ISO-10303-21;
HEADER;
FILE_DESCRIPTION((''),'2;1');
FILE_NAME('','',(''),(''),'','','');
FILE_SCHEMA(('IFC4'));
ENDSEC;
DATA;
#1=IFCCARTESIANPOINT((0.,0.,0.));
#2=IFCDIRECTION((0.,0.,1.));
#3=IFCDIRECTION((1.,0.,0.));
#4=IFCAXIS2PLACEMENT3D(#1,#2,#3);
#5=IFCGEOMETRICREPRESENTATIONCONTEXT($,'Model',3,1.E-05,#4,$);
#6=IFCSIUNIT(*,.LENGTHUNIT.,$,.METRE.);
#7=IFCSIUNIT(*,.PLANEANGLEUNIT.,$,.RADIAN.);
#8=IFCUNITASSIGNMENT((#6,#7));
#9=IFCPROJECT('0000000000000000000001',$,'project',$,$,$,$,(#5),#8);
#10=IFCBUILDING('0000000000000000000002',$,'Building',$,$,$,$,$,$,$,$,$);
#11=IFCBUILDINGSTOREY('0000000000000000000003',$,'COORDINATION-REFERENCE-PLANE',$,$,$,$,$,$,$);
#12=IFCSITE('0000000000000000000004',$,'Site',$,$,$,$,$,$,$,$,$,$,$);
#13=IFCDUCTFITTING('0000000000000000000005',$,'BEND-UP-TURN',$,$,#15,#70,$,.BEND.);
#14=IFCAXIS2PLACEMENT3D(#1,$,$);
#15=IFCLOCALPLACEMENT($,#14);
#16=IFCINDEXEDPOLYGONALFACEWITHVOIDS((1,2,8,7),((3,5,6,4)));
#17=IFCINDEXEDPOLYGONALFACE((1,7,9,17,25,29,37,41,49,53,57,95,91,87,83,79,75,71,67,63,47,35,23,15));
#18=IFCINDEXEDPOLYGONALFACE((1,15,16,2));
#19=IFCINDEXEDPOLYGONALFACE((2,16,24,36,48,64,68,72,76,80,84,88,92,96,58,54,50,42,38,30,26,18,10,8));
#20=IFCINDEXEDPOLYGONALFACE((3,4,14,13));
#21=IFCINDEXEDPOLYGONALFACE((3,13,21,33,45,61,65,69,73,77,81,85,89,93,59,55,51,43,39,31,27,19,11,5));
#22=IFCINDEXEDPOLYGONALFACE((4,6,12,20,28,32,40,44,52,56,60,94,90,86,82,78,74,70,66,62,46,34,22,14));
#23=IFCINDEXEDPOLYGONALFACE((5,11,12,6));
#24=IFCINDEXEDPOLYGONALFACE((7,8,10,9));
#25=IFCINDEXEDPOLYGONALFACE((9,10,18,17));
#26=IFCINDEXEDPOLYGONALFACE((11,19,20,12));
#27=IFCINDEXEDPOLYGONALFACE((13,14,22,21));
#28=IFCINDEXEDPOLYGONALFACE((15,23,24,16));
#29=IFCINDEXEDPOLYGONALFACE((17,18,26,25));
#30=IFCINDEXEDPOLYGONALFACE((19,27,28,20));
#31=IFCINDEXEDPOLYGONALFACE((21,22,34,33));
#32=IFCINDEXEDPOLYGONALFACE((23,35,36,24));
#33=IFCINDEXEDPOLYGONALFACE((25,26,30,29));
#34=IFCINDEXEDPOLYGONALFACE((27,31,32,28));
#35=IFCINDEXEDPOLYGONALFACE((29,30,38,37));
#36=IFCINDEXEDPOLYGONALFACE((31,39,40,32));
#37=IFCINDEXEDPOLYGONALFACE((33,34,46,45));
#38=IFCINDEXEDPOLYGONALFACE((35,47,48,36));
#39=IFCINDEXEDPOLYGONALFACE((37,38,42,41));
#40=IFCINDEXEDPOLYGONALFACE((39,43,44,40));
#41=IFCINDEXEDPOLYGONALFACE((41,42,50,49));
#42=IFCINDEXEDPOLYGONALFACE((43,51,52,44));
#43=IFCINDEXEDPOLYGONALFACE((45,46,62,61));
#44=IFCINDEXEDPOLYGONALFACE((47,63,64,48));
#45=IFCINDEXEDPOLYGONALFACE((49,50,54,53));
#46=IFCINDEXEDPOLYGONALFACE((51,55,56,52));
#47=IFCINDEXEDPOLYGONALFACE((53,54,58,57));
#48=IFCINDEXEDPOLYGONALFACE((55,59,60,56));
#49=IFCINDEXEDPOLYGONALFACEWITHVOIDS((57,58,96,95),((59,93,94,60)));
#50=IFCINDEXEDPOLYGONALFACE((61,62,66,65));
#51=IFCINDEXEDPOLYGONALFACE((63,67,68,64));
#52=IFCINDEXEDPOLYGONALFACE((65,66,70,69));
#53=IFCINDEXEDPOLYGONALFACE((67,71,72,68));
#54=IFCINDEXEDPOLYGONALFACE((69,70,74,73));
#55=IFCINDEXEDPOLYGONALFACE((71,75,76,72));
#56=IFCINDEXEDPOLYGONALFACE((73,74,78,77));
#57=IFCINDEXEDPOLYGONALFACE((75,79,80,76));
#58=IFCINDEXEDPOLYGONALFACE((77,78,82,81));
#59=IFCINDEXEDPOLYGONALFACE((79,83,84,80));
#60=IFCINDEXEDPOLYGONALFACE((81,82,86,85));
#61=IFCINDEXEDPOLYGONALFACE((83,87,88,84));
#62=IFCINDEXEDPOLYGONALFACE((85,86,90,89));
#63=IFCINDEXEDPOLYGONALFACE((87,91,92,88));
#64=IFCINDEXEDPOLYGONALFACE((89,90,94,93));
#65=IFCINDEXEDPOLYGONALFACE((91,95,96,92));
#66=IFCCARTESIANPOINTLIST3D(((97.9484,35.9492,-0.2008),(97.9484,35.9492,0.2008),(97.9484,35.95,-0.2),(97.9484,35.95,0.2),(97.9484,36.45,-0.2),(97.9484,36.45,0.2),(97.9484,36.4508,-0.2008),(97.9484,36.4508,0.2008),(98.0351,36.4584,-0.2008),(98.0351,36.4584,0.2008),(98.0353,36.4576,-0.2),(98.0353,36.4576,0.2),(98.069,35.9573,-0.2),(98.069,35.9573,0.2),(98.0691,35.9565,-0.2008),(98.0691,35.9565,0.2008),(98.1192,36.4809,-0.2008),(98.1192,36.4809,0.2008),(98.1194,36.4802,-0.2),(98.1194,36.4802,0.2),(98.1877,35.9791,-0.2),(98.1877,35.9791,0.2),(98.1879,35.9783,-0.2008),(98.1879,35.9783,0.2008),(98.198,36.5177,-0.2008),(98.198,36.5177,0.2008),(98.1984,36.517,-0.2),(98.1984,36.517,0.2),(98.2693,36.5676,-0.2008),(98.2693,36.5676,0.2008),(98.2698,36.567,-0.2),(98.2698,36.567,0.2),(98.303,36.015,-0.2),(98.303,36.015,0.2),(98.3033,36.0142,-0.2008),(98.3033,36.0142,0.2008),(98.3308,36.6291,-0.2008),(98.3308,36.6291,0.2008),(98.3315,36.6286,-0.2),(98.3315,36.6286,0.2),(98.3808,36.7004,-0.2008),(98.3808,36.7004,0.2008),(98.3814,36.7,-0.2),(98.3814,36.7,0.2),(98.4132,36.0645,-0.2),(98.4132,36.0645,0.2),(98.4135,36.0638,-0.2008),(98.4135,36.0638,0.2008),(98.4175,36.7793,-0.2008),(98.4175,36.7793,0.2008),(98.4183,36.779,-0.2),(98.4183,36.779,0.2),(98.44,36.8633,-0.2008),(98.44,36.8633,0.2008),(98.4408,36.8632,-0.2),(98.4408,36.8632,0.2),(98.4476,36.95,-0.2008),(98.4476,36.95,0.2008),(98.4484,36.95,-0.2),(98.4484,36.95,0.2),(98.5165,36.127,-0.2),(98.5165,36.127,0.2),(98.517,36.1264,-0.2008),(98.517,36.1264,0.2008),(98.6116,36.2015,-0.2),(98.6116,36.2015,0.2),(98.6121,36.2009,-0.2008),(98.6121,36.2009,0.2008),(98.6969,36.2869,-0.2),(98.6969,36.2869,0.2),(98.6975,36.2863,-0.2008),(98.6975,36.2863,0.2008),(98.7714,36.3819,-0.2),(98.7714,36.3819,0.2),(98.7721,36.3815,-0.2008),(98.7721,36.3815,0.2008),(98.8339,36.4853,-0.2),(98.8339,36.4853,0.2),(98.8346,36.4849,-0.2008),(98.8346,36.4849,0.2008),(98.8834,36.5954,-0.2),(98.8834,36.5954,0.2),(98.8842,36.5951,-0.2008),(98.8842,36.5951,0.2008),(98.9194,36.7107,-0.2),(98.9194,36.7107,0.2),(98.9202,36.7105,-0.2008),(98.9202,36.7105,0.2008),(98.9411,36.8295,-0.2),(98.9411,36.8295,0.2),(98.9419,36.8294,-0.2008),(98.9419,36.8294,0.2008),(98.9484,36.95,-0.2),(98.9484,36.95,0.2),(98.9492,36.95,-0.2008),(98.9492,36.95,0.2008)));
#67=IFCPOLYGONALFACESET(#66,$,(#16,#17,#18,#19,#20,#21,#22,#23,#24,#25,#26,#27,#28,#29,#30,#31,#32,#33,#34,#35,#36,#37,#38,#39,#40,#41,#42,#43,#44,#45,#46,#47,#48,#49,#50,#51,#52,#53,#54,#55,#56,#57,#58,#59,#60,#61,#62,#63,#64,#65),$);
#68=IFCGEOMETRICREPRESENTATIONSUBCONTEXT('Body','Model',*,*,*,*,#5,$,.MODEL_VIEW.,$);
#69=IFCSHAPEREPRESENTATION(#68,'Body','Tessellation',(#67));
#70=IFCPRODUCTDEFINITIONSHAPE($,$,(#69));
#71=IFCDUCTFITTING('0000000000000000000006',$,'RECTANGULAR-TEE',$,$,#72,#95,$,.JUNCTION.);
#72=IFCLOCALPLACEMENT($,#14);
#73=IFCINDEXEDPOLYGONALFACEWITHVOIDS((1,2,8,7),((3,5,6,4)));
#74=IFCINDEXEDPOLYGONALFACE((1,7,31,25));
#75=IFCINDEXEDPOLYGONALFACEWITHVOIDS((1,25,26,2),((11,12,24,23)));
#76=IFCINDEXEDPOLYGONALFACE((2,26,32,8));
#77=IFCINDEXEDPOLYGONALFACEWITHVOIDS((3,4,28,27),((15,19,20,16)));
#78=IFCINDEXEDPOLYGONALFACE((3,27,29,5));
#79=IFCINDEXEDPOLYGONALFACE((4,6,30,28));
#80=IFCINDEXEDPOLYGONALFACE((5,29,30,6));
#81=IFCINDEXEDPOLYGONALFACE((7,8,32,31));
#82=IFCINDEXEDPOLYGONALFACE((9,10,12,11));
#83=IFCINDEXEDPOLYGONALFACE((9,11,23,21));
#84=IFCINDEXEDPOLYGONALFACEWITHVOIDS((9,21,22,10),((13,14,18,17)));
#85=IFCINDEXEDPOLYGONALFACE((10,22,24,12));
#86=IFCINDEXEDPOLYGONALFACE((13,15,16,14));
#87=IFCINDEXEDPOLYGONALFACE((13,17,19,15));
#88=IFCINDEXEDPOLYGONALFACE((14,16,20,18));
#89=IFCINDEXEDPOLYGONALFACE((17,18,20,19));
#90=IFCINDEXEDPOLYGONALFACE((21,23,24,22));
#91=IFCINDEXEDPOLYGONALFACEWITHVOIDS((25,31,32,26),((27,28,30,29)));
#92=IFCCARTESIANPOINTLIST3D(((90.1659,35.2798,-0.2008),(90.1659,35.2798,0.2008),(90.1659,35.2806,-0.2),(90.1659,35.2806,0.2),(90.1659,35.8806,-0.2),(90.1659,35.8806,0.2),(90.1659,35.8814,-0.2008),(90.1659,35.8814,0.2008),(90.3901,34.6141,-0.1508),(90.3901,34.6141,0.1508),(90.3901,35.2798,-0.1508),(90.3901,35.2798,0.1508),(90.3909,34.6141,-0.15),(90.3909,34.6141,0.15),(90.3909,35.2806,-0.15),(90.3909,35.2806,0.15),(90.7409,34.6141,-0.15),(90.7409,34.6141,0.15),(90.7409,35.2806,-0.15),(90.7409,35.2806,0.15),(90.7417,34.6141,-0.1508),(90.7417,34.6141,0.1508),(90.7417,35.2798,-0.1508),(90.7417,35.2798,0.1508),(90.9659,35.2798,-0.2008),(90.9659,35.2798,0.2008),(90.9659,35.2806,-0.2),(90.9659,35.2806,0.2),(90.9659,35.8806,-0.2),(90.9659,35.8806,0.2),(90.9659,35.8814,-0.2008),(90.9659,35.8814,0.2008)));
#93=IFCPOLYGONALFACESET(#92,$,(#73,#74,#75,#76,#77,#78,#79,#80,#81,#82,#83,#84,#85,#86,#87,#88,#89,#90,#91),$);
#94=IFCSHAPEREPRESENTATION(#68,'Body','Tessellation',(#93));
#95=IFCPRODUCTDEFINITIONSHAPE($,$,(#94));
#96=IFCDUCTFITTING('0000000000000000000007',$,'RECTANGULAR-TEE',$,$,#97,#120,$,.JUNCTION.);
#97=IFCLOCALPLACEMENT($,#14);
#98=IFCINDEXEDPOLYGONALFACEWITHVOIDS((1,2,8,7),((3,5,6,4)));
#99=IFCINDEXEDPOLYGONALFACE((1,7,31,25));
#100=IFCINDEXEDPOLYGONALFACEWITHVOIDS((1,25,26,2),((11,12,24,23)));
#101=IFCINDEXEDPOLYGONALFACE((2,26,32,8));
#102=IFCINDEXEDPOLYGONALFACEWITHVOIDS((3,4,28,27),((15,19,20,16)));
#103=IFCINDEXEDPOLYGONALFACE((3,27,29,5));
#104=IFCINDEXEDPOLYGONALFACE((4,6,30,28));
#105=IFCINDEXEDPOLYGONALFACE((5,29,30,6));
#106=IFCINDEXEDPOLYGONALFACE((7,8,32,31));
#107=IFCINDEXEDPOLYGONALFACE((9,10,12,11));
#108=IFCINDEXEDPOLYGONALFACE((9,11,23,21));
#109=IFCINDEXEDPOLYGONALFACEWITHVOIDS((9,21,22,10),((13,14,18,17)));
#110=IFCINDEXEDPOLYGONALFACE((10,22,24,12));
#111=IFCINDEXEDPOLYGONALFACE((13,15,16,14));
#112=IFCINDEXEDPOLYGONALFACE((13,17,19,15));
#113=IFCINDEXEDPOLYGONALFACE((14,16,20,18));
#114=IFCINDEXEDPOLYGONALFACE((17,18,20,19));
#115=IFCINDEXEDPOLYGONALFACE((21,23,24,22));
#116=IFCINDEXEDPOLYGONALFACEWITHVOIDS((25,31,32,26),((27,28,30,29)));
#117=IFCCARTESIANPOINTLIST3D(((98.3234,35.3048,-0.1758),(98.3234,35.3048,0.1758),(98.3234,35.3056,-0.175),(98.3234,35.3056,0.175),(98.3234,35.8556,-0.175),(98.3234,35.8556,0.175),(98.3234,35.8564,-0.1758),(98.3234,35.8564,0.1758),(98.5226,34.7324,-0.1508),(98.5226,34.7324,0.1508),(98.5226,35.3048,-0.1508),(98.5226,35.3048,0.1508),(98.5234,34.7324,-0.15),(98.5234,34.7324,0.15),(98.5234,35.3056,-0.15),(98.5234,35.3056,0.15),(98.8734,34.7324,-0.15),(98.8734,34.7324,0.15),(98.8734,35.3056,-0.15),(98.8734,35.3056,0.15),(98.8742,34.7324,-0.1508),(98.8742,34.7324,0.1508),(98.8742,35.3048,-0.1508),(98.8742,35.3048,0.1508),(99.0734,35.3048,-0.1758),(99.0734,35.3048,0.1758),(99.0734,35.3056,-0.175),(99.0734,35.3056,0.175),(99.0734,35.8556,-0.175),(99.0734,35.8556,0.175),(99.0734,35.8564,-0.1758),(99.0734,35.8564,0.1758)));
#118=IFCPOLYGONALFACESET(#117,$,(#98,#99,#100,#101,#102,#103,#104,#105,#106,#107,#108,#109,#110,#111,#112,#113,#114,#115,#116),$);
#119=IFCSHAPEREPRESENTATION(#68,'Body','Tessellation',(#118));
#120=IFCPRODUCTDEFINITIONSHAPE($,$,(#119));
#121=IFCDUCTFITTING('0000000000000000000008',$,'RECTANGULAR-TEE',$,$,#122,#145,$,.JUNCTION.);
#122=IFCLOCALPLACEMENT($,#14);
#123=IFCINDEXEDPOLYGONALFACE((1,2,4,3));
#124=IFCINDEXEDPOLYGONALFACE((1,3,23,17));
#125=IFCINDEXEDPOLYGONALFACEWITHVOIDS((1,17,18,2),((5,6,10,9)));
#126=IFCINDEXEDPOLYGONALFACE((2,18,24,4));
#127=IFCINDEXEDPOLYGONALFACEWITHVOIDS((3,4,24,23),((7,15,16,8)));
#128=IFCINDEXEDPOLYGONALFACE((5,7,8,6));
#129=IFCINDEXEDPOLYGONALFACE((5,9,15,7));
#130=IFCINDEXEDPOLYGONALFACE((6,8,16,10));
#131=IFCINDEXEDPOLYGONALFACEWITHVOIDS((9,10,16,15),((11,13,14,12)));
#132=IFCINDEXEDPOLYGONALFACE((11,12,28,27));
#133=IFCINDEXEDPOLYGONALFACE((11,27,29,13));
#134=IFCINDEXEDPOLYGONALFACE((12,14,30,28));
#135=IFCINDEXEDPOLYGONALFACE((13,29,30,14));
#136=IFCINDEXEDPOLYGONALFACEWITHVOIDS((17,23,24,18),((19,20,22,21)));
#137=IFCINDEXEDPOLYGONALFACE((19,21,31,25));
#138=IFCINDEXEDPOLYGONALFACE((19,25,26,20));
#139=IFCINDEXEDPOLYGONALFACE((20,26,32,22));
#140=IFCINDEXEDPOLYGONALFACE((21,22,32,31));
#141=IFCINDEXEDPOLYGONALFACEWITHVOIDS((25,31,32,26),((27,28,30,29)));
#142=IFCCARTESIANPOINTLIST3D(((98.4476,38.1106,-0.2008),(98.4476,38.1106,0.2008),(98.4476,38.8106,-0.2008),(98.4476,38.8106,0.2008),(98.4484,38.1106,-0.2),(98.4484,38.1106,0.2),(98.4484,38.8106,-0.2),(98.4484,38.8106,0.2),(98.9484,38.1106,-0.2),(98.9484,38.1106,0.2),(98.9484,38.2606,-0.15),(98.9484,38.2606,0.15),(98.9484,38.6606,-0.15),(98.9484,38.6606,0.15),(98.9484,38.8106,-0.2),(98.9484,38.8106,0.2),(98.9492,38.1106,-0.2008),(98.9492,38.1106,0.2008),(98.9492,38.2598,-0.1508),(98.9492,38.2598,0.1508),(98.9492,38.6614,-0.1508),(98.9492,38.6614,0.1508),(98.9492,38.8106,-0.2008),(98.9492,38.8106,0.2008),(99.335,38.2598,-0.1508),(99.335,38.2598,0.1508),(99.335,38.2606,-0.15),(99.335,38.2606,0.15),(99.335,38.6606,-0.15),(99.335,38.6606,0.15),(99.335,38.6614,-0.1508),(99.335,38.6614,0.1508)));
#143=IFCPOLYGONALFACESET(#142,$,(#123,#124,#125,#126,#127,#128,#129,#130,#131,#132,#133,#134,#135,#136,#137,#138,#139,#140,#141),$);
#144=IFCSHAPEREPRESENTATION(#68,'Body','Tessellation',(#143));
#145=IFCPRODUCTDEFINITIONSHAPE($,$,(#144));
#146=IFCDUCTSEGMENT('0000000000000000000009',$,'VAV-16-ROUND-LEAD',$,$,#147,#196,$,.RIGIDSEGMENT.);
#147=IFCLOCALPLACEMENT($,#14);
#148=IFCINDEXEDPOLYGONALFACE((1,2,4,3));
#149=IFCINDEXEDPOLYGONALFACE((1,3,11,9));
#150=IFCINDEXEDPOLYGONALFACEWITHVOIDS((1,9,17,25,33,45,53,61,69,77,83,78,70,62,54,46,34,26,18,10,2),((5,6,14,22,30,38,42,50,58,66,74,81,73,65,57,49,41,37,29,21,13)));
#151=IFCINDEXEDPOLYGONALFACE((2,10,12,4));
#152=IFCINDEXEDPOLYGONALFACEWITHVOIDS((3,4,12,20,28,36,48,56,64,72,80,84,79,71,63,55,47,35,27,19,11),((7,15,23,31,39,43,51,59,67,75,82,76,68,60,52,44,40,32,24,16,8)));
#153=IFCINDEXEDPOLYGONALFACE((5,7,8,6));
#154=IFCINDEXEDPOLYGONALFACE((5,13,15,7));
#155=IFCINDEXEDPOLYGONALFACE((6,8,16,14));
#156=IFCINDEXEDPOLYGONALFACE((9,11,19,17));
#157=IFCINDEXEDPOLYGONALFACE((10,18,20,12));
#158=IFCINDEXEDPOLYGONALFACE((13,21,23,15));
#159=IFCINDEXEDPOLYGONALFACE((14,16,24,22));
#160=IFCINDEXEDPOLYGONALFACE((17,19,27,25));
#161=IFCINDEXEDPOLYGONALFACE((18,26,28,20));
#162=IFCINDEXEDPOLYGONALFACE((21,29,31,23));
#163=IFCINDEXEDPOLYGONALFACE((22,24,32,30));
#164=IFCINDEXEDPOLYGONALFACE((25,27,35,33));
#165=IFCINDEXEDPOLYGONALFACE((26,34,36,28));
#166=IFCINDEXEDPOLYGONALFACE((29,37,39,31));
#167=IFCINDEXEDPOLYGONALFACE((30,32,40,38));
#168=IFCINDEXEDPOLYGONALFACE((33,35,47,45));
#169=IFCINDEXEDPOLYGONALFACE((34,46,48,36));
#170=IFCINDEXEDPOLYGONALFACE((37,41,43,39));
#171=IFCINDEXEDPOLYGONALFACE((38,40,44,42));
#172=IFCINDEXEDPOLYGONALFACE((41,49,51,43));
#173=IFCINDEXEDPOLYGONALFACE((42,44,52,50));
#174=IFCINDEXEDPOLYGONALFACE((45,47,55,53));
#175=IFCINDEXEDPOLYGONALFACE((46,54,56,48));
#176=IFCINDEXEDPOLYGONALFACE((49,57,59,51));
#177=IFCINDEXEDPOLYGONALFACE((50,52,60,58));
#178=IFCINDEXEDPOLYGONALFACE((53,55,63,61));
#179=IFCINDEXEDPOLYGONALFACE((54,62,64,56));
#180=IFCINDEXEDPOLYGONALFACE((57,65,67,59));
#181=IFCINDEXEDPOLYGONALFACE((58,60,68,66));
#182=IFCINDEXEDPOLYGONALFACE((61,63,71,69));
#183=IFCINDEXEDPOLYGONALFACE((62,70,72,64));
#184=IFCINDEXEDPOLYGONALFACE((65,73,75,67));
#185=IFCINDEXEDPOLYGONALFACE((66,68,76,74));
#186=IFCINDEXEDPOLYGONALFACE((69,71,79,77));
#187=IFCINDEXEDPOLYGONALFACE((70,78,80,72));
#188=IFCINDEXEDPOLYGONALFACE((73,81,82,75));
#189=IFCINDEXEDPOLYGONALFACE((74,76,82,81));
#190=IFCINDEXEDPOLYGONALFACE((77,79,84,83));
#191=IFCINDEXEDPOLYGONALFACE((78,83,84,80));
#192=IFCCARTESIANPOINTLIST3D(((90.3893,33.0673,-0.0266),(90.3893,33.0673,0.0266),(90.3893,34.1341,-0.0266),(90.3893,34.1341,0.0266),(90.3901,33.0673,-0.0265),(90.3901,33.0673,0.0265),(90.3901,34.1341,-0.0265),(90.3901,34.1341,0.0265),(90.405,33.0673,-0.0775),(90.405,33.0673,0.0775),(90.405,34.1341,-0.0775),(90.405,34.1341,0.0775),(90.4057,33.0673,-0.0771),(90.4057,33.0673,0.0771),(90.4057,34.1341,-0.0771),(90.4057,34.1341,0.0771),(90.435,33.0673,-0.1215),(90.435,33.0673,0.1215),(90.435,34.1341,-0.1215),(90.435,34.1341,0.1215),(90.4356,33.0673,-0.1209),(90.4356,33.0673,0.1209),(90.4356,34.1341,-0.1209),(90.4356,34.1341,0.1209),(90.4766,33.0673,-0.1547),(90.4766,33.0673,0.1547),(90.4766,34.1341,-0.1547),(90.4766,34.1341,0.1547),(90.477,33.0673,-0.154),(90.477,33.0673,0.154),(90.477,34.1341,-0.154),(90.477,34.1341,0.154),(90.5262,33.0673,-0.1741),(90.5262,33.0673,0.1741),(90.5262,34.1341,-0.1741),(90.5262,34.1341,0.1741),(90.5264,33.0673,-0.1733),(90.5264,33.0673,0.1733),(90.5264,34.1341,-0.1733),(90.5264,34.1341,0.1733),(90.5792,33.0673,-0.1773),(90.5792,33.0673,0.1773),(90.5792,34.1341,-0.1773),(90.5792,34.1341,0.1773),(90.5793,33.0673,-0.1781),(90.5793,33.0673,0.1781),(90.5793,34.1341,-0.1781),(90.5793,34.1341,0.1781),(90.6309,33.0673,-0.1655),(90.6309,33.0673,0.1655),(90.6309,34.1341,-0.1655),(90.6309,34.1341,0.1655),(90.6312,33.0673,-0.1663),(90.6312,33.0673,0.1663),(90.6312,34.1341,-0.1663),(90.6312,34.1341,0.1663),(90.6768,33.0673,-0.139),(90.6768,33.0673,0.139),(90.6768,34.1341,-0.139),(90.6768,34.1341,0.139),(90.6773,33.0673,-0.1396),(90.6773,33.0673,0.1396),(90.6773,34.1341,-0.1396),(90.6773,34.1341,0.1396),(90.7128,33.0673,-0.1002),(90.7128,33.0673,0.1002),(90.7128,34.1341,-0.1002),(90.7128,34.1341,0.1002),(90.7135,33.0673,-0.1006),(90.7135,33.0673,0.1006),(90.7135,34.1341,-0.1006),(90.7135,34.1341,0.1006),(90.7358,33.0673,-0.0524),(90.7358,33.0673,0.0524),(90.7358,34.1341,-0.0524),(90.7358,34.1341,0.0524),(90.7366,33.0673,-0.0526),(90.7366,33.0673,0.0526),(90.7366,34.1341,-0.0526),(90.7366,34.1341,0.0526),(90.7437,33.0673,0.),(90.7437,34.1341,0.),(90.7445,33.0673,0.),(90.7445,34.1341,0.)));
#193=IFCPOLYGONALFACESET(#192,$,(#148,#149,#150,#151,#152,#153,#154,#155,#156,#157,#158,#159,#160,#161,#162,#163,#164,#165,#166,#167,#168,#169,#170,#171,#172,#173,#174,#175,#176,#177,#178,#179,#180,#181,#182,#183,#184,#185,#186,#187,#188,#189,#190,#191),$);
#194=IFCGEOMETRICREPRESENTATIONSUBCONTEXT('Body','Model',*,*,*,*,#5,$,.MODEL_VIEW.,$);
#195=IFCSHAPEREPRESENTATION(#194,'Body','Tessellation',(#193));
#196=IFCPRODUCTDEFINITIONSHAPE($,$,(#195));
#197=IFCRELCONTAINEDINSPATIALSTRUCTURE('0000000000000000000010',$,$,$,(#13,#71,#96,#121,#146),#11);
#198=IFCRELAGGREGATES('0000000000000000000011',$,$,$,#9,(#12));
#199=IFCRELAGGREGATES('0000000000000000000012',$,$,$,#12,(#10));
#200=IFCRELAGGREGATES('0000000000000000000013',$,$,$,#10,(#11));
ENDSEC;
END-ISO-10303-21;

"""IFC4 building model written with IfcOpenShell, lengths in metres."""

from ifc_helpers import new_model, entity, si_unit, frame, origin, origin_with_axes, place, context, subcontext, project, spatial, rectangle, hollow_circle, extrude, boolean, element, save


model = new_model("IFC4")

# Units and contexts
model_context = context("Model", 3, precision=1e-05, world=origin_with_axes())
body_context_1 = subcontext(model_context, "Body", "Model", "MODEL_VIEW")
body_context_2 = subcontext(model_context, "Body", "Model", "MODEL_VIEW")
ifc_project = project(units=[si_unit("LENGTHUNIT", "METRE"), si_unit("PLANEANGLEUNIT", "RADIAN")], contexts=[model_context])

# Site, building, storey
site = spatial("IfcSite", under=ifc_project, Name="Site")
building = spatial("IfcBuilding", under=site, Name="Building")
storey = spatial("IfcBuildingStorey", under=building, Name="COORDINATION-REFERENCE-PLANE")

# Duct fittings
duct_fitting_1_placement = place(None, frame((97.9484, 36.95, 0.0), z_axis=(0.0, 0.0, 1.0), x_axis=(0.0, -1.0, 0.0)))
cartesian_point_1 = entity("IfcCartesianPoint", [0.0, 0.0, 0.0])
element("IfcDuctFitting", 1, at=duct_fitting_1_placement, inside=storey, Name="BEND-UP-TURN", PredefinedType="BEND", context=body_context_1, shape_type="SweptSolid", body=[
    entity("IfcRevolvedAreaSolid", entity("IfcRectangleHollowProfileDef", "AREA", None, entity("IfcAxis2Placement2D", entity("IfcCartesianPoint", [0.75, 0.0])), 0.5016, 0.4016, 0.0008), entity("IfcAxis2Placement3D", cartesian_point_1, entity("IfcDirection", [0.0, -1.0, 0.0]), entity("IfcDirection", [1.0, 0.0, 0.0])), entity("IfcAxis1Placement", cartesian_point_1, entity("IfcDirection", [0.0, 1.0, 0.0])), 1.570796),
])
duct_fitting_2_placement = place(None, frame((90.5659, 35.5806, 0.0), z_axis=(1.0, 0.0, 0.0), x_axis=(0.0, -1.0, 0.0)))
solid_1 = boolean("UNION", extrude(rectangle(XDim=0.6, YDim=0.4), frame((0.0, 0.0, -0.4), z_axis=(0.0, 0.0, 1.0), x_axis=(1.0, 0.0, 0.0)), (0.0, 0.0, 1.0), 0.8), extrude(rectangle(XDim=0.35, YDim=0.3), frame((0.0, 0.0, 0.0), z_axis=(1.0, 0.0, 0.0), x_axis=(0.0, 0.0, -1.0)), (0.0, 0.0, 1.0), 0.9665))
element("IfcDuctFitting", 2, at=duct_fitting_2_placement, inside=storey, Name="RECTANGULAR-TEE", PredefinedType="JUNCTION", context=body_context_1, shape_type="CSG", body=[
    boolean("DIFFERENCE", boolean("UNION", extrude(rectangle(XDim=0.6016, YDim=0.4016), frame((0.0, 0.0, -0.4), z_axis=(0.0, 0.0, 1.0), x_axis=(1.0, 0.0, 0.0)), (0.0, 0.0, 1.0), 0.8), extrude(rectangle(XDim=0.3516, YDim=0.3016), frame((0.0, 0.0, 0.0), z_axis=(1.0, 0.0, 0.0), x_axis=(0.0, 0.0, -1.0)), (0.0, 0.0, 1.0), 0.9665)), solid_1),
])
duct_fitting_3_placement = place(None, frame((98.6984, 35.5806, 0.0), z_axis=(1.0, 0.0, 0.0), x_axis=(0.0, -1.0, 0.0)))
solid_2 = boolean("UNION", extrude(rectangle(XDim=0.55, YDim=0.35), frame((0.0, 0.0, -0.375), z_axis=(0.0, 0.0, 1.0), x_axis=(1.0, 0.0, 0.0)), (0.0, 0.0, 1.0), 0.75), extrude(rectangle(XDim=0.35, YDim=0.3), frame((0.0, 0.0, 0.0), z_axis=(1.0, 0.0, 0.0), x_axis=(0.0, 0.0, -1.0)), (0.0, 0.0, 1.0), 0.8482))
element("IfcDuctFitting", 3, at=duct_fitting_3_placement, inside=storey, Name="RECTANGULAR-TEE", PredefinedType="JUNCTION", context=body_context_1, shape_type="CSG", body=[
    boolean("DIFFERENCE", boolean("UNION", extrude(rectangle(XDim=0.5516, YDim=0.3516), frame((0.0, 0.0, -0.375), z_axis=(0.0, 0.0, 1.0), x_axis=(1.0, 0.0, 0.0)), (0.0, 0.0, 1.0), 0.75), extrude(rectangle(XDim=0.3516, YDim=0.3016), frame((0.0, 0.0, 0.0), z_axis=(1.0, 0.0, 0.0), x_axis=(0.0, 0.0, -1.0)), (0.0, 0.0, 1.0), 0.8482)), solid_2),
])
duct_fitting_4_placement = place(None, frame((98.6984, 38.4606, 0.0), z_axis=(0.0, 1.0, 0.0), x_axis=(1.0, 0.0, 0.0)))
solid_3 = boolean("UNION", extrude(rectangle(XDim=0.5, YDim=0.4), frame((0.0, 0.0, -0.35), z_axis=(0.0, 0.0, 1.0), x_axis=(1.0, 0.0, 0.0)), (0.0, 0.0, 1.0), 0.7), extrude(rectangle(XDim=0.4, YDim=0.3), frame((0.0, 0.0, 0.0), z_axis=(1.0, 0.0, 0.0), x_axis=(0.0, 0.0, -1.0)), (0.0, 0.0, 1.0), 0.6366))
element("IfcDuctFitting", 4, at=duct_fitting_4_placement, inside=storey, Name="RECTANGULAR-TEE", PredefinedType="JUNCTION", context=body_context_1, shape_type="CSG", body=[
    boolean("DIFFERENCE", boolean("UNION", extrude(rectangle(XDim=0.5016, YDim=0.4016), frame((0.0, 0.0, -0.35), z_axis=(0.0, 0.0, 1.0), x_axis=(1.0, 0.0, 0.0)), (0.0, 0.0, 1.0), 0.7), extrude(rectangle(XDim=0.4016, YDim=0.3016), frame((0.0, 0.0, 0.0), z_axis=(1.0, 0.0, 0.0), x_axis=(0.0, 0.0, -1.0)), (0.0, 0.0, 1.0), 0.6366)), solid_3),
])

# Duct segment
for number, where, z_axis, x_axis, name in (
    (5, (90.5659, 34.1341, 0.0), (0.0, -1.0, 0.0), (1.0, 0.0, 0.0), "VAV-16-ROUND-LEAD"),
):
    element("IfcDuctSegment", number, at=place(None, frame(where, z_axis=z_axis, x_axis=x_axis)), inside=storey, Name=name, PredefinedType="RIGIDSEGMENT", context=body_context_2, shape_type="SweptSolid", body=[
        extrude(hollow_circle(Radius=0.1786, WallThickness=0.0008), origin(), (0.0, 0.0, 1.0), 1.0668),
    ])

save(model, "model.ifc")
